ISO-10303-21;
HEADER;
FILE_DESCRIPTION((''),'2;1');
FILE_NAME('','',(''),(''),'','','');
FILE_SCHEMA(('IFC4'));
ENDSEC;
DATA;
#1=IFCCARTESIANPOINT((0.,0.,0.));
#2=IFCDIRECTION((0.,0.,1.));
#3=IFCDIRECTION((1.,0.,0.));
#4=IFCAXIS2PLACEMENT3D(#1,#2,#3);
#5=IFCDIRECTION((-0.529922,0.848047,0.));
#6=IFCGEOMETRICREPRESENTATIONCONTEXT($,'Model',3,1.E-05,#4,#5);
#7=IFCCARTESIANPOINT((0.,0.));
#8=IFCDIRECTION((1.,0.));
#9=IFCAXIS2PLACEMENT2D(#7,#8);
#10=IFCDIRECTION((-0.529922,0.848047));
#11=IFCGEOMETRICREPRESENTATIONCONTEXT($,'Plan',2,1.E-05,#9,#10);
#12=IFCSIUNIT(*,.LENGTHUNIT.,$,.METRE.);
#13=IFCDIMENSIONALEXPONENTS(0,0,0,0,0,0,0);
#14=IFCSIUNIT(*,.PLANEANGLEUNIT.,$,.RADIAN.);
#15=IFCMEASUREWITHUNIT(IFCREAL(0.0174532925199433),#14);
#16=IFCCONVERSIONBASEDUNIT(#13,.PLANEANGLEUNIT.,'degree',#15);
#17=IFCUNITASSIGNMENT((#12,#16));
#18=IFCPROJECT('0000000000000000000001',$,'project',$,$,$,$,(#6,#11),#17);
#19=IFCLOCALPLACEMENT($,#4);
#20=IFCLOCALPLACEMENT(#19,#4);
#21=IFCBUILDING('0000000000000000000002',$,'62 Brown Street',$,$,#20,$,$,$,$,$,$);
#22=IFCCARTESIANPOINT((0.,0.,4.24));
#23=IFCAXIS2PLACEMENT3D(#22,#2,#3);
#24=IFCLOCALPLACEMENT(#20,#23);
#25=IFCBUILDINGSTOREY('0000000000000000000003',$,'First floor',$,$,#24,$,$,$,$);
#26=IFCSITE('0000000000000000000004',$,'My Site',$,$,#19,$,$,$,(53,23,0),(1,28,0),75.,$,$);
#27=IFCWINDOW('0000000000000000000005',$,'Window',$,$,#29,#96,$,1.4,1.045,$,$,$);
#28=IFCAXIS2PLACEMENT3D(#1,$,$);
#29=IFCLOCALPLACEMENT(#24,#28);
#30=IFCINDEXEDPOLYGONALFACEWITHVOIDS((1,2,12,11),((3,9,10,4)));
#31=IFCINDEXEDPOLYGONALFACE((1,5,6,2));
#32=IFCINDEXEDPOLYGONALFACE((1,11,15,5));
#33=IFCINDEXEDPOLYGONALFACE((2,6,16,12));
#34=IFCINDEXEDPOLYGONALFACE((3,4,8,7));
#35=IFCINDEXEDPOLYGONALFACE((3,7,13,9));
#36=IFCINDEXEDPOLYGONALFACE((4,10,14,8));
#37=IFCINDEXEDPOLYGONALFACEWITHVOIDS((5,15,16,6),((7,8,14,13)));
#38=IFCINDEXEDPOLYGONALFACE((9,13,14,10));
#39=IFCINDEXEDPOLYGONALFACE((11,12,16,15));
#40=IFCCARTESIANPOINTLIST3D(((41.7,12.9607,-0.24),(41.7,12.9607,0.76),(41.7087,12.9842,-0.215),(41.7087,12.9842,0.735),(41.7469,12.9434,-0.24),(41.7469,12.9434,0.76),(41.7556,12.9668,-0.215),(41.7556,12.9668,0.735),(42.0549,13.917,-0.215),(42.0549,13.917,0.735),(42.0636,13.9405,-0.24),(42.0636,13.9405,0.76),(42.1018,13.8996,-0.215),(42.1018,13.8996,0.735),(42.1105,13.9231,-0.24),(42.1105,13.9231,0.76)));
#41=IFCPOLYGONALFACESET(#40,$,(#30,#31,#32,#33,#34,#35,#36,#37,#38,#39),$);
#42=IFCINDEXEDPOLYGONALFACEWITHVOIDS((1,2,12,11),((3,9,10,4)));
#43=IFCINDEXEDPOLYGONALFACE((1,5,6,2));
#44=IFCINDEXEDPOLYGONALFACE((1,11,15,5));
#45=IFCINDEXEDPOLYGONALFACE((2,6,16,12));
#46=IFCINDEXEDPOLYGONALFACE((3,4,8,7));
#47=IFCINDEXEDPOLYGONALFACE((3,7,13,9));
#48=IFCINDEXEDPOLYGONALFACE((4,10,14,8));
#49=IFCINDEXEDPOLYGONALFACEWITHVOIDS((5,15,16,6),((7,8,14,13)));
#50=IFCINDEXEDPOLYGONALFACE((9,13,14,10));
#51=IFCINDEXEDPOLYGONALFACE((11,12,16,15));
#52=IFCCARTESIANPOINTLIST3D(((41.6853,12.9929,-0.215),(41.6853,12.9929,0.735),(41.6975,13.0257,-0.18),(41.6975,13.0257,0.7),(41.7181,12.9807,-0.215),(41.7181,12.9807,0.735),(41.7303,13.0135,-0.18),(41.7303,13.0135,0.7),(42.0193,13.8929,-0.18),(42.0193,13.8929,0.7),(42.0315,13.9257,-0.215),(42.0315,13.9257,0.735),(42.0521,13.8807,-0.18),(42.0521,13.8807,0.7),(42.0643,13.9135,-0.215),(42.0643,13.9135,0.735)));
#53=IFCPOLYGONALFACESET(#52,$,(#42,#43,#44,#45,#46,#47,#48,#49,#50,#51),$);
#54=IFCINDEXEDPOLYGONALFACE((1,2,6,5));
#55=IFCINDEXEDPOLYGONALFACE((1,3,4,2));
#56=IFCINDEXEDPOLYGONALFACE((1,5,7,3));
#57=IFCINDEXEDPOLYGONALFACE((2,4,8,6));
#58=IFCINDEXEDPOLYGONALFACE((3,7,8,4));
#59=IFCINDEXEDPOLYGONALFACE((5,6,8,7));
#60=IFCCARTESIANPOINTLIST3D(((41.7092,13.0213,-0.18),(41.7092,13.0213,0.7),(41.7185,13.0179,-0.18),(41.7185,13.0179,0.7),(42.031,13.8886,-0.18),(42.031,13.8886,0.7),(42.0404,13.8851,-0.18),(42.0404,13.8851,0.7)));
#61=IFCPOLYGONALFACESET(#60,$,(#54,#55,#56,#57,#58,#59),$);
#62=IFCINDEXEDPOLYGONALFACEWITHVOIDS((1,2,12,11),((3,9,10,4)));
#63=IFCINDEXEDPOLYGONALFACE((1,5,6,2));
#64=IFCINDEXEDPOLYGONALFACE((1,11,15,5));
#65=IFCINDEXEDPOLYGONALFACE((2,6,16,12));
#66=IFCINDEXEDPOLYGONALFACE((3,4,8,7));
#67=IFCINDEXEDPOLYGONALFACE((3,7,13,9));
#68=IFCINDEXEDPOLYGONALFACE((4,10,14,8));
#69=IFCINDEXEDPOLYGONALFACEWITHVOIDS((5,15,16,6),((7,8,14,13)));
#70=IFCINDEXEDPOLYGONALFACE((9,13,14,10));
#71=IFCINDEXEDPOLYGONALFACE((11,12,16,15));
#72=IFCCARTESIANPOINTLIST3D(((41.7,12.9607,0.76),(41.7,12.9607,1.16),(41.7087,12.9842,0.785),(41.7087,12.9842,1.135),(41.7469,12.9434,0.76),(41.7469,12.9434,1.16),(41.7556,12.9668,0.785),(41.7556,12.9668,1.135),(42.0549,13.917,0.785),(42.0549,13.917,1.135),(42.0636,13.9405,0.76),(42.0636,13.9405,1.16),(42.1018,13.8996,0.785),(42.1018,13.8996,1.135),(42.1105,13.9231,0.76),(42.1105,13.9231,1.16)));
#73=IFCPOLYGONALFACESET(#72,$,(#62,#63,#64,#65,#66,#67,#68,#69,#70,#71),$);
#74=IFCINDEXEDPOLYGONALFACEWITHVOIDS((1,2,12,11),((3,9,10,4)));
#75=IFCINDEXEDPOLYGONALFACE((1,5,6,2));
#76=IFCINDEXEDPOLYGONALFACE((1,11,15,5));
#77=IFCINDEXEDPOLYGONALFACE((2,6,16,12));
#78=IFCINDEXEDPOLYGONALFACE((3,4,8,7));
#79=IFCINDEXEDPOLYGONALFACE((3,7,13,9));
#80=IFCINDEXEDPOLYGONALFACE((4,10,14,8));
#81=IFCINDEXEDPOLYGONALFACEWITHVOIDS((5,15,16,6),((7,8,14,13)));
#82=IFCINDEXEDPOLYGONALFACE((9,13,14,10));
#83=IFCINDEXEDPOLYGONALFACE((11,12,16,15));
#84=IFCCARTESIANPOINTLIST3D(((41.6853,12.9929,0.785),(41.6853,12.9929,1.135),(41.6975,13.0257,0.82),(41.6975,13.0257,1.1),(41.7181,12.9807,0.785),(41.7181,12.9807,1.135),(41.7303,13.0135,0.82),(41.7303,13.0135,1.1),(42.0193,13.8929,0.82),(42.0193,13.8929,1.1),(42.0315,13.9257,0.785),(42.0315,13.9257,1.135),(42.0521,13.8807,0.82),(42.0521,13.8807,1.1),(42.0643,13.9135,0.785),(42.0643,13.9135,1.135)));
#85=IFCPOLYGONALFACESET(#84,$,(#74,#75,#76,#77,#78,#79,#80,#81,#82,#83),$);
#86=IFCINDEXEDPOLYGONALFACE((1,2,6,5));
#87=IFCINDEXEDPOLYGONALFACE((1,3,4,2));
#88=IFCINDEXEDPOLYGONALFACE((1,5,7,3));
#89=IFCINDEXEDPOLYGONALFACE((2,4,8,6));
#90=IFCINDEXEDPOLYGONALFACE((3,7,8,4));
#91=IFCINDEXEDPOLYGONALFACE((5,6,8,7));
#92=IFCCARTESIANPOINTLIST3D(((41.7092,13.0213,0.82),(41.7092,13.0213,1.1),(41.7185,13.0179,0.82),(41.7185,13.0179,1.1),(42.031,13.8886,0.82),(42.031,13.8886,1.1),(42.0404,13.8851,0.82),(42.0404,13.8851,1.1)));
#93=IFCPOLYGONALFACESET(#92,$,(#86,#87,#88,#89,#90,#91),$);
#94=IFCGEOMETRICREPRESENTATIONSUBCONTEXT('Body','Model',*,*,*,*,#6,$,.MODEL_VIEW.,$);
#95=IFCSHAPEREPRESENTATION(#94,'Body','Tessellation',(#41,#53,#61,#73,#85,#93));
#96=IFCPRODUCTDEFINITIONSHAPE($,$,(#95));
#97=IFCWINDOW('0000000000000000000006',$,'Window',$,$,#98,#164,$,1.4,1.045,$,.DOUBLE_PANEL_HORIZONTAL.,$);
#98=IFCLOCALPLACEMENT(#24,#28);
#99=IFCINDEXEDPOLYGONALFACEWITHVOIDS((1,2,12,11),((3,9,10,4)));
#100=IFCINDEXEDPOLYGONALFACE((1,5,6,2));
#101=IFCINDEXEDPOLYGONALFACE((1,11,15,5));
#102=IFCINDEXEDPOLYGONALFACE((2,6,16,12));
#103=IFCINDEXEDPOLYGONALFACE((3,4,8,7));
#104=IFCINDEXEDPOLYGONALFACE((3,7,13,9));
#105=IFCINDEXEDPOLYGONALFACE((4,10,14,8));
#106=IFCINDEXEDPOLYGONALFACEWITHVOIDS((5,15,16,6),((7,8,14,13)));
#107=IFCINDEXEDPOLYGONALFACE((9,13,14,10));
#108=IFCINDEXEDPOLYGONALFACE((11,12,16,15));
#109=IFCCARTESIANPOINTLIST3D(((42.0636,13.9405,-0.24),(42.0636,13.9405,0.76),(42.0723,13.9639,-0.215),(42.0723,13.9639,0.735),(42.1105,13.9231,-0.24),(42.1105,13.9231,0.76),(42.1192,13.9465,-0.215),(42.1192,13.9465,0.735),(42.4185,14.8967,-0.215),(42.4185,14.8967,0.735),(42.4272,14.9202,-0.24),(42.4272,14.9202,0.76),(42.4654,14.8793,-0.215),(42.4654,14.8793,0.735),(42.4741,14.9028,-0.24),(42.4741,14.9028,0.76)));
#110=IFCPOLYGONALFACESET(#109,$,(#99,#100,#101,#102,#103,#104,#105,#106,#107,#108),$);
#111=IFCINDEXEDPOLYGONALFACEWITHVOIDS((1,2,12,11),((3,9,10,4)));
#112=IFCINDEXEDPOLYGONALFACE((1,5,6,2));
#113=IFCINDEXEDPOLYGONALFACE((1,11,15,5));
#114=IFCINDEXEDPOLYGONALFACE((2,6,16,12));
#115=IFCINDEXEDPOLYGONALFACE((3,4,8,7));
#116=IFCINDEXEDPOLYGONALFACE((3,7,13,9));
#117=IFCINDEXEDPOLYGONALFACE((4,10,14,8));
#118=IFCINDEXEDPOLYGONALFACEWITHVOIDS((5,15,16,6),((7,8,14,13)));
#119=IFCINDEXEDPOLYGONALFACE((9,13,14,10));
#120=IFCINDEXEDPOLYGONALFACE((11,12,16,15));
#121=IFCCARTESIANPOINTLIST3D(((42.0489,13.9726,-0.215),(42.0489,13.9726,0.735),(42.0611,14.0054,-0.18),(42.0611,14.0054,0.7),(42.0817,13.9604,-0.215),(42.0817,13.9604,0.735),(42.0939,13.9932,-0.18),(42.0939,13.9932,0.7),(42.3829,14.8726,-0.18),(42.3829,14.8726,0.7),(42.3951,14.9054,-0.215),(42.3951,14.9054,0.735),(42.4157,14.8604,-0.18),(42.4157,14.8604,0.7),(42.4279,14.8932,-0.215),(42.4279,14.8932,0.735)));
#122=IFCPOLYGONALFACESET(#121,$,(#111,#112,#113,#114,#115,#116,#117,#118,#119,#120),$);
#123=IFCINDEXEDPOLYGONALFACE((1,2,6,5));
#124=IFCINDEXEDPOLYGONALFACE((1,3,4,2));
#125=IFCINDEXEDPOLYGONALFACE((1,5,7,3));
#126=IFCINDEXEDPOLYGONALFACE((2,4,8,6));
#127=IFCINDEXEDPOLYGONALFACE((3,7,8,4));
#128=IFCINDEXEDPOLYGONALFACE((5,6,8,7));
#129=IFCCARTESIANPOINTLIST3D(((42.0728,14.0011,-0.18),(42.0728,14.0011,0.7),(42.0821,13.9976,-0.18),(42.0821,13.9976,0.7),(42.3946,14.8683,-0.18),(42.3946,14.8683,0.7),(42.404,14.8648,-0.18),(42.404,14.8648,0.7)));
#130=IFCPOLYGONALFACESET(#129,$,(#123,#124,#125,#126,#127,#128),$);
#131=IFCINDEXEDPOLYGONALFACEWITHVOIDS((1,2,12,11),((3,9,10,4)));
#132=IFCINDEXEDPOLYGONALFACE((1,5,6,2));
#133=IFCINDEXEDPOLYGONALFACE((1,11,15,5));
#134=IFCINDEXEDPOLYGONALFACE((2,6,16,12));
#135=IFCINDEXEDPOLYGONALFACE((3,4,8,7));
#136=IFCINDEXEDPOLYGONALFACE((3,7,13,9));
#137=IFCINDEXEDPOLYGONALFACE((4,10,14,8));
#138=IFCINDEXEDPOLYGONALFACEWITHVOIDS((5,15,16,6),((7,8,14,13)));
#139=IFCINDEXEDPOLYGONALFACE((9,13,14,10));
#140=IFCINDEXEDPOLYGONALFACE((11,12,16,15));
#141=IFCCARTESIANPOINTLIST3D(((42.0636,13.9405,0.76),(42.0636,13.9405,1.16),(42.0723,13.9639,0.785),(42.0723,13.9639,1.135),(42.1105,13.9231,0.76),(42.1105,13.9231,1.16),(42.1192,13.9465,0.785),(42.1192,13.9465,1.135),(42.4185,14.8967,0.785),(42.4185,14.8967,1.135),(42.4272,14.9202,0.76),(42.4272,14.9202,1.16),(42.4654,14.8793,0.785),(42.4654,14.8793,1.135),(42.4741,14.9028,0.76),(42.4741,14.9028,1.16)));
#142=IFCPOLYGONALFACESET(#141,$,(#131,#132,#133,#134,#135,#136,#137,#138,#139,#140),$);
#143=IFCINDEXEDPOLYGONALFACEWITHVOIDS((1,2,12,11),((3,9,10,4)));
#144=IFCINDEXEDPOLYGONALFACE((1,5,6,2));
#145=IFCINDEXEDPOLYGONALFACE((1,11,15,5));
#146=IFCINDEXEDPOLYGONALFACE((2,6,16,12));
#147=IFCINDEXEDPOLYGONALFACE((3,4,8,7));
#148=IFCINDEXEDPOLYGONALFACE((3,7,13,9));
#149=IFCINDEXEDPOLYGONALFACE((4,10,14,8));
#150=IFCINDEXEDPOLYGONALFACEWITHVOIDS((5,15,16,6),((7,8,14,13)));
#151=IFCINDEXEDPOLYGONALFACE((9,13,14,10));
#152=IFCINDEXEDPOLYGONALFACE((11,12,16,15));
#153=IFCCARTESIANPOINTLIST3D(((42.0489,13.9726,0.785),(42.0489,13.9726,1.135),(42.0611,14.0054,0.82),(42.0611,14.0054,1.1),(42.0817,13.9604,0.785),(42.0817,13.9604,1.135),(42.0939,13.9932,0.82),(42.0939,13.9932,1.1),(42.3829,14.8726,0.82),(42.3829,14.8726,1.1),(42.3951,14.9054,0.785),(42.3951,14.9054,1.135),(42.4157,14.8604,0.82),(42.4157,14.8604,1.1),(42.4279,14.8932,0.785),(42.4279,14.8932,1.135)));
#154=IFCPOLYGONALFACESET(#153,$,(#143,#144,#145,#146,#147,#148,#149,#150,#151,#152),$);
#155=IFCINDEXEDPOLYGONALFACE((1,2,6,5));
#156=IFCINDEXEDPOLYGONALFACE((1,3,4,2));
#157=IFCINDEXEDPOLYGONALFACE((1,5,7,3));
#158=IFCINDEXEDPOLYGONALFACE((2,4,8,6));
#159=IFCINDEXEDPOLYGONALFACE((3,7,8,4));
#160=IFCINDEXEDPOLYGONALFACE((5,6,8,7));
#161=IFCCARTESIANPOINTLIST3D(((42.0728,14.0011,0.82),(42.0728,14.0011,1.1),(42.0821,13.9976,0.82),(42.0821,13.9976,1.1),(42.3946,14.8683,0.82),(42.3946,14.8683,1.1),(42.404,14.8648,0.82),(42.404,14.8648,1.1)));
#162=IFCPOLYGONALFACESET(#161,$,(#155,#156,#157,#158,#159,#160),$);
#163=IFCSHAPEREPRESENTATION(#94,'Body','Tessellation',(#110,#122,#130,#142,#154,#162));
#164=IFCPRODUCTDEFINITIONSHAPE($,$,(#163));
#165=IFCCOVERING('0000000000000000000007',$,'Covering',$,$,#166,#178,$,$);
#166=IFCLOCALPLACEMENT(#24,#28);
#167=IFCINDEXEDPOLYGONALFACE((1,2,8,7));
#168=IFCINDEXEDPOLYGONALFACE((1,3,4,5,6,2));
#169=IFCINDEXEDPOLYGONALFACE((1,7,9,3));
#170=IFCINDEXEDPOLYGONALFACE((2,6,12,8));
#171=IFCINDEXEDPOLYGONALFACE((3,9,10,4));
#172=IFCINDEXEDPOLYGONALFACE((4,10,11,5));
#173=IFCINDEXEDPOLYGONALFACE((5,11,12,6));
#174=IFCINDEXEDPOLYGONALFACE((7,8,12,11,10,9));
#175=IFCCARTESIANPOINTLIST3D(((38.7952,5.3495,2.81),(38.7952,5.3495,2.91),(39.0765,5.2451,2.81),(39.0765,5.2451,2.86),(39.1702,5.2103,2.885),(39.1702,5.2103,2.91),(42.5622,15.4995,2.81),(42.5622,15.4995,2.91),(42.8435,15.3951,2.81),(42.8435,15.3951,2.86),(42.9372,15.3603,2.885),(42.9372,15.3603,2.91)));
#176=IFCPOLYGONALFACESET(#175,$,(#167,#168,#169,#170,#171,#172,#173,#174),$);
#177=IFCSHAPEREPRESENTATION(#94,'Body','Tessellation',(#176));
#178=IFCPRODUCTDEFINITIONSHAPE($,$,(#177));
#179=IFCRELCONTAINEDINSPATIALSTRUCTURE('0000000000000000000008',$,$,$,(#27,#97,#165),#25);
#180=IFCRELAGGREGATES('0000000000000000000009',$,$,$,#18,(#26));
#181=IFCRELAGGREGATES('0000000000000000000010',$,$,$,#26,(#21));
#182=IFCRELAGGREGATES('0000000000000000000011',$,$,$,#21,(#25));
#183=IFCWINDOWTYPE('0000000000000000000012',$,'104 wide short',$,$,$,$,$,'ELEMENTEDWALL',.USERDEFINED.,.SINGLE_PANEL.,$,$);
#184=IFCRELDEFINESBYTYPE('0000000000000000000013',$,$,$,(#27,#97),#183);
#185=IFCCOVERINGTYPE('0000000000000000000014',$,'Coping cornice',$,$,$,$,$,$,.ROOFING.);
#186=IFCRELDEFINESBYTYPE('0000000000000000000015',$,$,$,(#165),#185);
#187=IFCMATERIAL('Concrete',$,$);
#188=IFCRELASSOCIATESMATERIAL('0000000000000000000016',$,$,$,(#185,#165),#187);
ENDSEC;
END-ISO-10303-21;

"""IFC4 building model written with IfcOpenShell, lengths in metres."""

from ifc_helpers import new_model, entity, si_unit, converted_unit, direction, frame, origin_with_axes, origin_2d_with_axis, place, context, subcontext, project, spatial, line, indexed_curve, outline, extrude, shape, source, transform, mapped, material, material_profile, profile_set, profile_usage, type_object, type_shapes, element, save


model = new_model("IFC4")

# Units and contexts
model_context = context("Model", 3, precision=1e-05, world=origin_with_axes(), true_north=direction((-0.529922, 0.848047, 0.0)))
plan_context = context("Plan", 2, precision=1e-05, world=origin_2d_with_axis(), true_north=direction((-0.529922, 0.848047)))
body_context_1 = subcontext(model_context, "Body", "Model", "MODEL_VIEW")
body_context_2 = subcontext(plan_context, "Body", "Plan", "PLAN_VIEW")
ifc_project = project(units=[si_unit("LENGTHUNIT", "METRE"), converted_unit("PLANEANGLEUNIT", "degree", entity("IfcReal", 0.0174532925199433), si_unit("PLANEANGLEUNIT", "RADIAN"), dimensions=[0, 0, 0, 0, 0, 0, 0])], contexts=[model_context, plan_context])

# Site, building, storey
site_placement = place(None, origin_with_axes())
site = spatial("IfcSite", under=ifc_project, at=site_placement, Name="My Site", RefLatitude=(53, 23, 0), RefLongitude=(1, 28, 0), RefElevation=75.0)
building_placement = place(site_placement, origin_with_axes())
building = spatial("IfcBuilding", under=site, at=building_placement, Name="62 Brown Street")
storey_placement = place(building_placement, frame((0.0, 0.0, 4.24), z_axis=(0.0, 0.0, 1.0), x_axis=(1.0, 0.0, 0.0)))
storey = spatial("IfcBuildingStorey", under=building, at=storey_placement, Name="First floor")

# Shared definitions
window_type_1 = type_object("IfcWindowType", Name="104 wide short", ElementType="ELEMENTEDWALL", PartitioningType="SINGLE_PANEL", PredefinedType="USERDEFINED")
shared_shape_1 = source(origin_with_axes(), body_context_1, "Body", "SweptSolid", [
    extrude(outline(indexed_curve([(0.0, 0.0), (1.045, 0.0), (1.045, 1.0), (0.0, 1.0)], segments=[line(1, 2, 3, 4, 1)]), holes=[indexed_curve([(0.025, 0.025), (1.02, 0.025), (1.02, 0.975), (0.025, 0.975)], segments=[line(1, 2, 3, 4, 1)])]), frame((0.0, 0.15, 0.0), z_axis=(0.0, -1.0, 0.0), x_axis=(1.0, 0.0, 0.0)), (0.0, 0.0, -1.0), 0.05),
    extrude(outline(indexed_curve([(0.0, 0.0), (0.995, 0.0), (0.995, 0.95), (0.0, 0.95)], segments=[line(1, 2, 3, 4, 1)]), holes=[indexed_curve([(0.035, 0.035), (0.96, 0.035), (0.96, 0.915), (0.035, 0.915)], segments=[line(1, 2, 3, 4, 1)])]), frame((0.025, 0.19, 0.025), z_axis=(0.0, -1.0, 0.0), x_axis=(1.0, 0.0, 0.0)), (0.0, 0.0, -1.0), 0.035),
    extrude(outline(indexed_curve([(0.035, 0.035), (0.96, 0.035), (0.96, 0.915), (0.035, 0.915)], segments=[line(1, 2, 3, 4, 1)])), frame((0.025, 0.2025, 0.025), z_axis=(0.0, -1.0, 0.0), x_axis=(1.0, 0.0, 0.0)), (0.0, 0.0, -1.0), 0.01),
    extrude(outline(indexed_curve([(0.0, 0.0), (1.045, 0.0), (1.045, 0.4), (0.0, 0.4)], segments=[line(1, 2, 3, 4, 1)]), holes=[indexed_curve([(0.025, 0.025), (1.02, 0.025), (1.02, 0.375), (0.025, 0.375)], segments=[line(1, 2, 3, 4, 1)])]), frame((0.0, 0.15, 1.0), z_axis=(0.0, -1.0, 0.0), x_axis=(1.0, 0.0, 0.0)), (0.0, 0.0, -1.0), 0.05),
    extrude(outline(indexed_curve([(0.0, 0.0), (0.995, 0.0), (0.995, 0.35), (0.0, 0.35)], segments=[line(1, 2, 3, 4, 1)]), holes=[indexed_curve([(0.035, 0.035), (0.96, 0.035), (0.96, 0.315), (0.035, 0.315)], segments=[line(1, 2, 3, 4, 1)])]), frame((0.025, 0.19, 1.025), z_axis=(0.0, -1.0, 0.0), x_axis=(1.0, 0.0, 0.0)), (0.0, 0.0, -1.0), 0.035),
    extrude(outline(indexed_curve([(0.035, 0.035), (0.96, 0.035), (0.96, 0.315), (0.035, 0.315)], segments=[line(1, 2, 3, 4, 1)])), frame((0.025, 0.2025, 1.025), z_axis=(0.0, -1.0, 0.0), x_axis=(1.0, 0.0, 0.0)), (0.0, 0.0, -1.0), 0.01),
])
shared_shape_2 = source(origin_with_axes(), body_context_2, "Body", "Curve2D", [
    entity("IfcIndexedPolyCurve", entity("IfcCartesianPointList2D", [[0.025, 0.15], [1.02, 0.15]])),
    entity("IfcIndexedPolyCurve", entity("IfcCartesianPointList2D", [[0.0, 0.2], [0.025, 0.2], [0.025, 0.15], [0.0, 0.15]]), [entity("IfcLineIndex", [1, 2, 3, 4, 1])]),
    entity("IfcIndexedPolyCurve", entity("IfcCartesianPointList2D", [[1.045, 0.2], [1.02, 0.2], [1.02, 0.15], [1.045, 0.15]]), [entity("IfcLineIndex", [1, 2, 3, 4, 1])]),
    entity("IfcIndexedPolyCurve", entity("IfcCartesianPointList2D", [[0.025, 0.19], [0.06, 0.19], [0.06, 0.225], [0.025, 0.225]]), [entity("IfcLineIndex", [1, 2, 3, 4, 1])]),
    entity("IfcIndexedPolyCurve", entity("IfcCartesianPointList2D", [[1.02, 0.19], [0.985, 0.19], [0.985, 0.225], [1.02, 0.225]]), [entity("IfcLineIndex", [1, 2, 3, 4, 1])]),
    entity("IfcIndexedPolyCurve", entity("IfcCartesianPointList2D", [[0.06, 0.19], [0.985, 0.19]])),
    entity("IfcIndexedPolyCurve", entity("IfcCartesianPointList2D", [[0.06, 0.225], [0.985, 0.225]])),
    entity("IfcIndexedPolyCurve", entity("IfcCartesianPointList2D", [[0.06, 0.2075], [0.985, 0.2075]])),
])
type_shapes(window_type_1, [shared_shape_1, shared_shape_2])

# Windows
for number, where, z_axis, x_axis, name in (
    (1, (41.8875, 12.8912, -0.24), (0.0, 0.0, 1.0), (0.347944, 0.937515, 0.0), "Window"),
):
    element("IfcWindow", number, at=place(storey_placement, frame(where, z_axis=z_axis, x_axis=x_axis)), inside=storey, type_object=window_type_1, Name=name, OverallHeight=1.4, OverallWidth=1.045, shapes=[
        shape(body_context_1, "Body", "MappedRepresentation", [mapped(shared_shape_1, transform((0.0, 0.0, 0.0), x_axis=(1.0, 0.0, 0.0), y_axis=(0.0, 1.0, 0.0), z_axis=(0.0, 0.0, 1.0), scale=1.0))]),
        shape(body_context_2, "Body", "MappedRepresentation", [mapped(shared_shape_2, transform((0.0, 0.0, 0.0), x_axis=(1.0, 0.0, 0.0), y_axis=(0.0, 1.0, 0.0), z_axis=(0.0, 0.0, 1.0), scale=1.0))]),
    ])
window_1_placement = place(storey_placement, frame((42.2511, 13.8709, -0.24), z_axis=(0.0, 0.0, 1.0), x_axis=(0.347944, 0.937515, 0.0)))
element("IfcWindow", 2, at=window_1_placement, inside=storey, type_object=window_type_1, Name="Window", OverallHeight=1.4, OverallWidth=1.045, PartitioningType="DOUBLE_PANEL_HORIZONTAL", shapes=[
    shape(body_context_1, "Body", "MappedRepresentation", [mapped(shared_shape_1, transform((0.0, 0.0, 0.0), x_axis=(1.0, 0.0, 0.0), y_axis=(0.0, 1.0, 0.0), z_axis=(0.0, 0.0, 1.0), scale=1.0))]),
    shape(body_context_2, "Body", "MappedRepresentation", [mapped(shared_shape_2, transform((0.0, 0.0, 0.0), x_axis=(1.0, 0.0, 0.0), y_axis=(0.0, 1.0, 0.0), z_axis=(0.0, 0.0, 1.0), scale=1.0))]),
])

# Covering
ifc_material_1 = material(Name="Concrete")
ifc_material_profile = material_profile(ifc_material_1, outline(indexed_curve([(-0.2, 0.1), (0.2, 0.1), (0.2, 0.075), (0.1, 0.05), (0.1, 0.0), (-0.2, 0.0)], segments=[line(5, 4), line(4, 3), line(3, 2), line(2, 1), line(1, 6), line(6, 5)], self_intersect=False)))
ifc_profile_set = profile_set([ifc_material_profile], Name="cornice")
ifc_profile_usage = profile_usage(ifc_profile_set, cardinal=5)
covering_type = type_object("IfcCoveringType", Name="Coping cornice", PredefinedType="ROOFING", material=ifc_profile_set)
covering_placement = place(storey_placement, frame((42.7497, 15.4299, 2.81), z_axis=(-0.347944, -0.937515, 0.0), x_axis=(0.937515, -0.347944, 0.0)))
element("IfcCovering", 3, at=covering_placement, inside=storey, type_object=covering_type, material=ifc_profile_usage, Name="Covering", context=body_context_1, shape_type="SweptSolid", body=[
    extrude(outline(indexed_curve([(-0.2, 0.1), (0.2, 0.1), (0.2, 0.075), (0.1, 0.05), (0.1, 0.0), (-0.2, 0.0)], segments=[line(5, 4), line(4, 3), line(3, 2), line(2, 1), line(1, 6), line(6, 5)], self_intersect=False)), origin_with_axes(), (0.0, 0.0, 1.0), 10.8265),
])

save(model, "model.ifc")
